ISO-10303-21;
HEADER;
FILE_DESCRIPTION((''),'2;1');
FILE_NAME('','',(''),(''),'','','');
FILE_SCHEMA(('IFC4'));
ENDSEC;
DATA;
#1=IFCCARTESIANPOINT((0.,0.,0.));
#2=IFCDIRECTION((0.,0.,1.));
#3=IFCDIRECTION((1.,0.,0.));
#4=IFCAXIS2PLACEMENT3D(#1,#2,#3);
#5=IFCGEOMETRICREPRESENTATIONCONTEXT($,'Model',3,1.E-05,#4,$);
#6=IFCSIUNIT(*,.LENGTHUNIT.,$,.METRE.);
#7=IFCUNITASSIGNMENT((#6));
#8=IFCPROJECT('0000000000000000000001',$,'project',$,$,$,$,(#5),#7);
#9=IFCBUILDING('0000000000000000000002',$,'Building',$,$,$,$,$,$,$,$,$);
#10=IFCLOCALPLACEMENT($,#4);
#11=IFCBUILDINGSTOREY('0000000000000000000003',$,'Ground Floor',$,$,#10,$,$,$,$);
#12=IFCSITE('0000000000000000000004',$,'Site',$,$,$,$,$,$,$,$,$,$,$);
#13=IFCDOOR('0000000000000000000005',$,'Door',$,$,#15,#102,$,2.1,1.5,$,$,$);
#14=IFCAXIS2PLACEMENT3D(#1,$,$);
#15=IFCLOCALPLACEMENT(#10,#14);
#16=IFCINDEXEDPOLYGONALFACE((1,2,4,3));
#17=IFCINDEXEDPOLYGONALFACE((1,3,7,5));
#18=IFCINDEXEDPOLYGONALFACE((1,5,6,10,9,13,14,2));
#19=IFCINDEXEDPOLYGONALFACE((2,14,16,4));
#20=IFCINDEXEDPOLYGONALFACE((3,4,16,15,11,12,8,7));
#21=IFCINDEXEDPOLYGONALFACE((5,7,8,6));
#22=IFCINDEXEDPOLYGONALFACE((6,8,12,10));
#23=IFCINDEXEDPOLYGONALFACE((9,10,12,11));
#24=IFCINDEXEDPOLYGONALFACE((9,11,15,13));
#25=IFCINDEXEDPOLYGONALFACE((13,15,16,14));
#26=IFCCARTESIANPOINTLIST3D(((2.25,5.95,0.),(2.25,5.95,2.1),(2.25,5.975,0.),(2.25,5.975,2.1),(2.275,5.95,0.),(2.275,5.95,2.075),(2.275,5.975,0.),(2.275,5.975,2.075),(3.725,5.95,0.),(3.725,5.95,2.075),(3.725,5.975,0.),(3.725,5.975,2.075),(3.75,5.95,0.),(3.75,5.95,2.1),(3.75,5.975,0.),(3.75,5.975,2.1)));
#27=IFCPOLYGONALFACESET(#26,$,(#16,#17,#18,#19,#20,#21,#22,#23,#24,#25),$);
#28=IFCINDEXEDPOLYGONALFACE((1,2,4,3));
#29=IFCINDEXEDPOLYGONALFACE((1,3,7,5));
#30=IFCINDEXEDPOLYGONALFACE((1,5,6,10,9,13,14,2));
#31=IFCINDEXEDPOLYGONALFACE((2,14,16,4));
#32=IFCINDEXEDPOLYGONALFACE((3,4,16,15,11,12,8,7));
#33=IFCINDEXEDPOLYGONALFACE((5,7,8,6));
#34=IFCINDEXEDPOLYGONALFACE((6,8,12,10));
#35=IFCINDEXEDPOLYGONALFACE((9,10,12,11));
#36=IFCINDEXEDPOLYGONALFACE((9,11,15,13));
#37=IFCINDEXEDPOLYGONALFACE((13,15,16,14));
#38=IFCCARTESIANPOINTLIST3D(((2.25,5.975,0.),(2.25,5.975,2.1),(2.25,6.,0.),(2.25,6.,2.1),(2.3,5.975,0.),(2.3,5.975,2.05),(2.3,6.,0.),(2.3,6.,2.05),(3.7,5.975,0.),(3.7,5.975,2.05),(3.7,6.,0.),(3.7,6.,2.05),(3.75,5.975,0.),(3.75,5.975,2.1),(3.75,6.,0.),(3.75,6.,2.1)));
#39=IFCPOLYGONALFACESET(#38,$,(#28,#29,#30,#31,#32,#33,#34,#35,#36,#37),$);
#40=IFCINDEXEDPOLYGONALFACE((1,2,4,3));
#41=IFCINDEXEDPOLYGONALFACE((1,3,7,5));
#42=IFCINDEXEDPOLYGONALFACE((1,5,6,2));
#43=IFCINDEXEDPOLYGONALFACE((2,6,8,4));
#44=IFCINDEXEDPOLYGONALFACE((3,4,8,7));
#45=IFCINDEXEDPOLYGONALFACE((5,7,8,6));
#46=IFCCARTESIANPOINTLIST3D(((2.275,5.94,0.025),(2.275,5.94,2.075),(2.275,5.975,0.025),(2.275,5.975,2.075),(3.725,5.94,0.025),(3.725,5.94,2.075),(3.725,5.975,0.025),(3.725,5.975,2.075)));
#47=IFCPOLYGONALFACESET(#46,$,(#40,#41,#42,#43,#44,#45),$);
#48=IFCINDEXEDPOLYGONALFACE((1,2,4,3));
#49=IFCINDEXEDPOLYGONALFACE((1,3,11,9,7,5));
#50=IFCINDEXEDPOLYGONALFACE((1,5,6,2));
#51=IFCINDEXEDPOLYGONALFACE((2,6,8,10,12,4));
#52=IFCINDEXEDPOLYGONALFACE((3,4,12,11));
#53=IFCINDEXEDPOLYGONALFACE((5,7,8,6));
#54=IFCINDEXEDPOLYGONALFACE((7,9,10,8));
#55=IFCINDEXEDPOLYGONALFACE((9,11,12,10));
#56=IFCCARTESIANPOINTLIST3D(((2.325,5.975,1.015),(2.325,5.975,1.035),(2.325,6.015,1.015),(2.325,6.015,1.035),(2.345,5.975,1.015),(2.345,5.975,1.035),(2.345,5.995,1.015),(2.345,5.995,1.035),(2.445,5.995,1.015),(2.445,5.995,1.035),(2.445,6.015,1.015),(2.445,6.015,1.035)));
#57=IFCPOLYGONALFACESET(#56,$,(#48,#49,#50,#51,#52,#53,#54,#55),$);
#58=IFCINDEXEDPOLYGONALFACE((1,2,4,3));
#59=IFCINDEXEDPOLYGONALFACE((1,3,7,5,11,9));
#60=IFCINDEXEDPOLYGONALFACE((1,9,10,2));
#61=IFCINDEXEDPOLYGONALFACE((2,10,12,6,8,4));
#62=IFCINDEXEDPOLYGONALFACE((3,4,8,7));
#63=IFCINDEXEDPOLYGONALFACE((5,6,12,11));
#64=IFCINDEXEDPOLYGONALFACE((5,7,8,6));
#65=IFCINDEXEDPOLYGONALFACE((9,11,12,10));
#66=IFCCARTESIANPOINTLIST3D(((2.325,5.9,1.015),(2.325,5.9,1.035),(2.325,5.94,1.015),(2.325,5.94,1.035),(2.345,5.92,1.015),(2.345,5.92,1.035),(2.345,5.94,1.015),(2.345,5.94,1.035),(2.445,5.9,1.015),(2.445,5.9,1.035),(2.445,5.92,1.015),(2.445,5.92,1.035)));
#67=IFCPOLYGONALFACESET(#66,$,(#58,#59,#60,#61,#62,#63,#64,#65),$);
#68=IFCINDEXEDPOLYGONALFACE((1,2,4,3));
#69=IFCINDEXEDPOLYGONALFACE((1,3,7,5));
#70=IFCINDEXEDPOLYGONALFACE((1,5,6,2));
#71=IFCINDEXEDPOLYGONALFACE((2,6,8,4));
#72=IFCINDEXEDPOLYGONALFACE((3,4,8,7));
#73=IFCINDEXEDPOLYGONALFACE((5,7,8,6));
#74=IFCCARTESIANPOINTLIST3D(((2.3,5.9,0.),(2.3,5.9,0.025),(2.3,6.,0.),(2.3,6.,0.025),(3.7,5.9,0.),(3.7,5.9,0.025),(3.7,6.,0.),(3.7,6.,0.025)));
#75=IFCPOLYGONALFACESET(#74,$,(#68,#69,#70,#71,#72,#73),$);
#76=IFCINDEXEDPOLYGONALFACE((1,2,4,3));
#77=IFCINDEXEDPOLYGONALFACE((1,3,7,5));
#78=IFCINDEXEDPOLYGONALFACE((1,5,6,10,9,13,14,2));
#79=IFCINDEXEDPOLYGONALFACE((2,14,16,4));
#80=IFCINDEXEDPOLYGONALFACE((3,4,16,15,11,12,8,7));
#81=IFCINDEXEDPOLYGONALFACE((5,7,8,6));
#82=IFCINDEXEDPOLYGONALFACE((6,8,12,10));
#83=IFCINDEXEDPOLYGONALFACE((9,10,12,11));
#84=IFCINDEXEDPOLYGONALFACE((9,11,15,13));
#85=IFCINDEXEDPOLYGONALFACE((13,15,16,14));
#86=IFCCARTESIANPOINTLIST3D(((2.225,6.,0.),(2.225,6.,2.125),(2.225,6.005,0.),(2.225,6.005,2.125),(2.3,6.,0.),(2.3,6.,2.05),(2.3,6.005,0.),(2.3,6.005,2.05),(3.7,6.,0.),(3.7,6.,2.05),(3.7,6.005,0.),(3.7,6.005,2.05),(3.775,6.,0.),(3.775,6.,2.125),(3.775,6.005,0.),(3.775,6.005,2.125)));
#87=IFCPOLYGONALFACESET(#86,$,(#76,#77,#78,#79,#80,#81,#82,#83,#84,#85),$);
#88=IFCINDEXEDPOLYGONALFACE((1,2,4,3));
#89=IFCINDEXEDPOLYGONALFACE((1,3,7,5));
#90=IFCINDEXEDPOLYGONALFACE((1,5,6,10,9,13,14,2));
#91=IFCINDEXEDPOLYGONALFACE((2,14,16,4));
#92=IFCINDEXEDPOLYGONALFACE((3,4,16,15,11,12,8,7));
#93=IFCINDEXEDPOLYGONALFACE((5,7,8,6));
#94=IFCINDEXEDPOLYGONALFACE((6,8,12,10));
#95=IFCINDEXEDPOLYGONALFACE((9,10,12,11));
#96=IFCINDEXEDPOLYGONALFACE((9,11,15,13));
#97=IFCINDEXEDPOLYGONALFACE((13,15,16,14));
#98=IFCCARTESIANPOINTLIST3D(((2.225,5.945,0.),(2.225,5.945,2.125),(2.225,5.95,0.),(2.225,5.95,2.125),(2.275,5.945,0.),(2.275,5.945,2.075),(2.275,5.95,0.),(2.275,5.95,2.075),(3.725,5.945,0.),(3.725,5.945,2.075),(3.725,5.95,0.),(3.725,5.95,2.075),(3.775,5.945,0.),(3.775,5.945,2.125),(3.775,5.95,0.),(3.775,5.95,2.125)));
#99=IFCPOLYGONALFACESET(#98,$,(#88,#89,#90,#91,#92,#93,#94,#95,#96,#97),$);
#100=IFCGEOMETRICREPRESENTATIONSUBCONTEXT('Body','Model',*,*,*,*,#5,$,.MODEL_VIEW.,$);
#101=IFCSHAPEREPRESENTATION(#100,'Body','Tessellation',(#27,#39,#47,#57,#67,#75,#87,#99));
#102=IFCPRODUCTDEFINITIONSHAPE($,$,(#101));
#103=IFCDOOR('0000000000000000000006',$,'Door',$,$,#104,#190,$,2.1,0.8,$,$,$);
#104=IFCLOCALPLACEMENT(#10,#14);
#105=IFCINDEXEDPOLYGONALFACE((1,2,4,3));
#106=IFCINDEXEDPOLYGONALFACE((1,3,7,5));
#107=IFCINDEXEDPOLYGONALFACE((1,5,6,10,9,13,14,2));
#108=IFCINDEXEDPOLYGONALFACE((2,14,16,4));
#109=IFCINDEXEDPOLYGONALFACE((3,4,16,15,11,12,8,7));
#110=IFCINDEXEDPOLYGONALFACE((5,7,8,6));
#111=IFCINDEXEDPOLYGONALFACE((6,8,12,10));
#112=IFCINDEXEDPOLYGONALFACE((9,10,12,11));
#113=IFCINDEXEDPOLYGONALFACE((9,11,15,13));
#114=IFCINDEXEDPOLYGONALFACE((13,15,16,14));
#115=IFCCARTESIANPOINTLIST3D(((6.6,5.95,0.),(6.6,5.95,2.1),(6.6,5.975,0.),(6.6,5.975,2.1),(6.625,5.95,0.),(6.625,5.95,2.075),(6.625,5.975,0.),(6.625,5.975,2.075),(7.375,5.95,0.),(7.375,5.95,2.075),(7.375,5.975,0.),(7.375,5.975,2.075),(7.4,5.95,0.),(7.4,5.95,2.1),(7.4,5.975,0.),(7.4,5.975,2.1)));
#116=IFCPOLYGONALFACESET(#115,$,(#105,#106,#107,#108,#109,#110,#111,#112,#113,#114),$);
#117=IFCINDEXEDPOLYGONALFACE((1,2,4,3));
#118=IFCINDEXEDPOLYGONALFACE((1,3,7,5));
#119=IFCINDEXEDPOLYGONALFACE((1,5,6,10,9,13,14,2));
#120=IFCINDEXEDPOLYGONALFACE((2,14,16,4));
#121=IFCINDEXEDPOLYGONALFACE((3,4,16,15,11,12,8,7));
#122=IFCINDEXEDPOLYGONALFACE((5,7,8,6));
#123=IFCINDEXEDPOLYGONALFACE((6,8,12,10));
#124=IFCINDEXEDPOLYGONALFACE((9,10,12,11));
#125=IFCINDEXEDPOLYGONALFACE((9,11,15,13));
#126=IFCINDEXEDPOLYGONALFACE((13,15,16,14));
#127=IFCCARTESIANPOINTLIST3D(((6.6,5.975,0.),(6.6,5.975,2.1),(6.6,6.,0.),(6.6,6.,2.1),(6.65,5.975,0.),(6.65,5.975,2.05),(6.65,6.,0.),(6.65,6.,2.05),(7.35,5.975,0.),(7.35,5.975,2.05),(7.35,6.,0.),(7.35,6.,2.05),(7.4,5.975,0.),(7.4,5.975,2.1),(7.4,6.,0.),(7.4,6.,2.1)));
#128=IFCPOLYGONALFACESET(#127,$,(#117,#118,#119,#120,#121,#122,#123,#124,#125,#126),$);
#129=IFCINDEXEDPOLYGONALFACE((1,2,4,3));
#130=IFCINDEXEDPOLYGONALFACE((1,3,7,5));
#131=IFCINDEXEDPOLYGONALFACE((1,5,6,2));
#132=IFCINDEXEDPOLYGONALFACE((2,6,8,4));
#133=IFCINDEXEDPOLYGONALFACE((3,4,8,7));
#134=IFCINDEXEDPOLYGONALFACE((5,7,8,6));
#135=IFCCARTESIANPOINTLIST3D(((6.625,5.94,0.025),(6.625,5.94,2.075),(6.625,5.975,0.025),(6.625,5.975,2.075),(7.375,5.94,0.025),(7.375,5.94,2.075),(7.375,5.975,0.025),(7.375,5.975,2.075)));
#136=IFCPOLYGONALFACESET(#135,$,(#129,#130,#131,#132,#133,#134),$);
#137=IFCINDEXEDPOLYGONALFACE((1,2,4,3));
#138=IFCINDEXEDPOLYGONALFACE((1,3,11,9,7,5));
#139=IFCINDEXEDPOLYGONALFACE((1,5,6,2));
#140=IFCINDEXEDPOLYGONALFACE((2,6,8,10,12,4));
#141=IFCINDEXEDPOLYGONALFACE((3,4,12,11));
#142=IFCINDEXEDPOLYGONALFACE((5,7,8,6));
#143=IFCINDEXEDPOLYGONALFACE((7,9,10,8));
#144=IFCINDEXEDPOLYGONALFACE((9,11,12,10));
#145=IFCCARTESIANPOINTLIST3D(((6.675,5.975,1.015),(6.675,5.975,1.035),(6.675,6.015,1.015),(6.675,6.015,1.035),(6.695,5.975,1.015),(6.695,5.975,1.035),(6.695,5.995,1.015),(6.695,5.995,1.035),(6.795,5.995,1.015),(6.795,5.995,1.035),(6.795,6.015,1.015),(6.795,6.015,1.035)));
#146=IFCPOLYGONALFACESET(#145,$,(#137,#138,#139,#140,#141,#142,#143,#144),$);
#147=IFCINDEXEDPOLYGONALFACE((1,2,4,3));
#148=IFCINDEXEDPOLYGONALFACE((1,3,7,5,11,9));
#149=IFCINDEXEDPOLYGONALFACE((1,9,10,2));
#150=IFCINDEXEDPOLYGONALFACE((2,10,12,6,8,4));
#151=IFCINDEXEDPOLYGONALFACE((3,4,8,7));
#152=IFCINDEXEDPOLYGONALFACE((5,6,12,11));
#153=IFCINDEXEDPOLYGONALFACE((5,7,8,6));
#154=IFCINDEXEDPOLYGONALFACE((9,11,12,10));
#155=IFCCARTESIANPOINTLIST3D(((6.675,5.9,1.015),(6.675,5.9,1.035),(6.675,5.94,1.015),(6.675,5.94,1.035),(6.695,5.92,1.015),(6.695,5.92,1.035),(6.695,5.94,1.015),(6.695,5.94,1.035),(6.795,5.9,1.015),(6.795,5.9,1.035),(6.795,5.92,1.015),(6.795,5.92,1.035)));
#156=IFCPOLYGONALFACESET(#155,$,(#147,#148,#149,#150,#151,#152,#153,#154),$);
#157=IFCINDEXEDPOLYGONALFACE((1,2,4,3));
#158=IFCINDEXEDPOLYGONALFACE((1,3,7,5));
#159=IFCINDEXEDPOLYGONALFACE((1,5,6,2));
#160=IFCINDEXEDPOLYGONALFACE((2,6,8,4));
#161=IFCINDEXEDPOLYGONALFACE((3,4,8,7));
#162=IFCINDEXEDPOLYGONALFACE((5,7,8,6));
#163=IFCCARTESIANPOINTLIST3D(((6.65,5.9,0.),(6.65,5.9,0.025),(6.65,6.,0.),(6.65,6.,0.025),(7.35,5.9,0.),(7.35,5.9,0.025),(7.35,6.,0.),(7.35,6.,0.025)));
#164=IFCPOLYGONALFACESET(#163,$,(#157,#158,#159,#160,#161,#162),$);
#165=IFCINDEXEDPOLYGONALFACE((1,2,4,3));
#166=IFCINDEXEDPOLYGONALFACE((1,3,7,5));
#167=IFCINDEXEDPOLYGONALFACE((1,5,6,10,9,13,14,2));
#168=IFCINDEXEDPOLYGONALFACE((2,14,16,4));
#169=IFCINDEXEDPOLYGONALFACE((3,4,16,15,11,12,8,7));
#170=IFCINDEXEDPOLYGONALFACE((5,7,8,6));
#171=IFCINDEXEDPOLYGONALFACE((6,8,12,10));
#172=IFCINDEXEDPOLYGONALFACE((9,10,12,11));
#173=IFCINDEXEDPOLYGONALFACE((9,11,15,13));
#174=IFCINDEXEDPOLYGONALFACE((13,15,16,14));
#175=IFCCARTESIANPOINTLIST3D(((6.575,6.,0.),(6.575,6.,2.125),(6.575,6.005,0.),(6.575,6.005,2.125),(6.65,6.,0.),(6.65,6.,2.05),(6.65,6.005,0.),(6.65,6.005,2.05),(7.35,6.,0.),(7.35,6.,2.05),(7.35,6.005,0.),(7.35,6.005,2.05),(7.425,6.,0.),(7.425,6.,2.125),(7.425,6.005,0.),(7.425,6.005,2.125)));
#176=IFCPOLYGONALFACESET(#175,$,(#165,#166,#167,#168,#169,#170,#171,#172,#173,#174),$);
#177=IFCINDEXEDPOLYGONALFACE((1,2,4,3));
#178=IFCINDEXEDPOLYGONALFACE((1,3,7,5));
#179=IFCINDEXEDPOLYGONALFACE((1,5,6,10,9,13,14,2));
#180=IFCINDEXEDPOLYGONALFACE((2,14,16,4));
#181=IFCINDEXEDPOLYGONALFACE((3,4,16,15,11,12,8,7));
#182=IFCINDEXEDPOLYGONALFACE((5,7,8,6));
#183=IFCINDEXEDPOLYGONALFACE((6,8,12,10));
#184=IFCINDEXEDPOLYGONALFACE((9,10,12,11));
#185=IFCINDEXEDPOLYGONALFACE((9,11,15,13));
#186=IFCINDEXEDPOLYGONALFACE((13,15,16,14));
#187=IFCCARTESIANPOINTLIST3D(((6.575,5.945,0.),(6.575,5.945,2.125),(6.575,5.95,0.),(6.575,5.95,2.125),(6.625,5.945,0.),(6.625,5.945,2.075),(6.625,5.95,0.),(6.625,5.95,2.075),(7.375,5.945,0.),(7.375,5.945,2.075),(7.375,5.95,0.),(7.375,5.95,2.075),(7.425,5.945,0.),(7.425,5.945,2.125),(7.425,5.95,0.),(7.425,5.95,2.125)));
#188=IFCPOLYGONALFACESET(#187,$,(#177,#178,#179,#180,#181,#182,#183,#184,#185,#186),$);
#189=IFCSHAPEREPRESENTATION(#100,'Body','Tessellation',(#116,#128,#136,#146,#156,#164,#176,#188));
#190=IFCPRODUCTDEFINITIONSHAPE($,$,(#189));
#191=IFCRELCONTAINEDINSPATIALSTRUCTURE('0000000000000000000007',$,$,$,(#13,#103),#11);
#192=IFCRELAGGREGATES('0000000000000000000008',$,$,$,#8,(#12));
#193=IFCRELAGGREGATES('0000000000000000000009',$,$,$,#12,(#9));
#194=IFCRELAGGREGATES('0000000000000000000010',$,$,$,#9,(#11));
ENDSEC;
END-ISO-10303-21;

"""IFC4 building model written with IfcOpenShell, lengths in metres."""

from ifc_helpers import new_model, si_unit, frame, origin_with_axes, place, context, subcontext, project, spatial, line, indexed_curve, outline, extrude, element, save


model = new_model("IFC4")

# Units and contexts
model_context = context("Model", 3, precision=1e-05, world=origin_with_axes())
body_context = subcontext(model_context, "Body", "Model", "MODEL_VIEW")
ifc_project = project(units=[si_unit("LENGTHUNIT", "METRE")], contexts=[model_context])

# Site, building, storey
site = spatial("IfcSite", under=ifc_project, Name="Site")
building = spatial("IfcBuilding", under=site, Name="Building")
storey_placement = place(None, origin_with_axes())
storey = spatial("IfcBuildingStorey", under=building, at=storey_placement, Name="Ground Floor")

# Doors
door_1_placement = place(storey_placement, frame((3.75, 6.0, 0.0), z_axis=(0.0, 0.0, 1.0), x_axis=(-1.0, 0.0, 0.0)))
element("IfcDoor", 1, at=door_1_placement, inside=storey, Name="Door", OverallHeight=2.1, OverallWidth=1.5, context=body_context, shape_type="SweptSolid", body=[
    extrude(outline(indexed_curve([(0.0, 0.0), (0.0, 2.1), (1.5, 2.1), (1.5, 0.0), (1.475, 0.0), (1.475, 2.075), (0.025, 2.075), (0.025, 0.0)], segments=[line(1, 2, 3, 4, 5, 6, 7, 8, 1)])), frame((0.0, 0.025, 0.0), z_axis=(0.0, -1.0, 0.0), x_axis=(1.0, 0.0, 0.0)), (0.0, 0.0, -1.0), 0.025),
    extrude(outline(indexed_curve([(0.0, 0.0), (0.0, 2.1), (1.5, 2.1), (1.5, 0.0), (1.45, 0.0), (1.45, 2.05), (0.05, 2.05), (0.05, 0.0)], segments=[line(1, 2, 3, 4, 5, 6, 7, 8, 1)])), frame((0.0, 0.0, 0.0), z_axis=(0.0, -1.0, 0.0), x_axis=(1.0, 0.0, 0.0)), (0.0, 0.0, -1.0), 0.025),
    extrude(outline(indexed_curve([(0.0, 0.0), (1.45, 0.0), (1.45, 0.035), (0.0, 0.035)], segments=[line(1, 2, 3, 4, 1)])), frame((0.025, 0.025, 0.025), z_axis=(0.0, 0.0, 1.0), x_axis=(1.0, 0.0, 0.0)), (0.0, 0.0, 1.0), 2.05),
    extrude(outline(indexed_curve([(0.0, 0.0), (0.0, -0.04), (-0.12, -0.04), (-0.12, -0.02), (-0.02, -0.02), (-0.02, 0.0)], segments=[line(1, 2, 3, 4, 5, 6, 1)])), frame((1.425, 0.025, 1.015), z_axis=(0.0, 0.0, 1.0), x_axis=(1.0, 0.0, 0.0)), (0.0, 0.0, 1.0), 0.02),
    extrude(outline(indexed_curve([(0.0, 0.0), (0.0, 0.04), (-0.12, 0.04), (-0.12, 0.02), (-0.02, 0.02), (-0.02, 0.0)], segments=[line(1, 2, 3, 4, 5, 6, 1)])), frame((1.425, 0.06, 1.015), z_axis=(0.0, 0.0, 1.0), x_axis=(1.0, 0.0, 0.0)), (0.0, 0.0, 1.0), 0.02),
    extrude(outline(indexed_curve([(0.0, 0.0), (1.4, 0.0), (1.4, 0.1), (0.0, 0.1)], segments=[line(1, 2, 3, 4, 1)])), frame((0.05, 0.0, 0.0), z_axis=(0.0, 0.0, 1.0), x_axis=(1.0, 0.0, 0.0)), (0.0, 0.0, 1.0), 0.025),
    extrude(outline(indexed_curve([(0.0, 0.0), (0.0, 2.125), (1.55, 2.125), (1.55, 0.0), (1.475, 0.0), (1.475, 2.05), (0.075, 2.05), (0.075, 0.0)], segments=[line(1, 2, 3, 4, 5, 6, 7, 8, 1)])), frame((-0.025, -0.005, 0.0), z_axis=(0.0, -1.0, 0.0), x_axis=(1.0, 0.0, 0.0)), (0.0, 0.0, -1.0), 0.005),
    extrude(outline(indexed_curve([(0.0, 0.0), (0.0, 2.125), (1.55, 2.125), (1.55, 0.0), (1.5, 0.0), (1.5, 2.075), (0.05, 2.075), (0.05, 0.0)], segments=[line(1, 2, 3, 4, 5, 6, 7, 8, 1)])), frame((-0.025, 0.05, 0.0), z_axis=(0.0, -1.0, 0.0), x_axis=(1.0, 0.0, 0.0)), (0.0, 0.0, -1.0), 0.005),
])
door_2_placement = place(storey_placement, frame((7.4, 6.0, 0.0), z_axis=(0.0, 0.0, 1.0), x_axis=(-1.0, 0.0, 0.0)))
element("IfcDoor", 2, at=door_2_placement, inside=storey, Name="Door", OverallHeight=2.1, OverallWidth=0.8, context=body_context, shape_type="SweptSolid", body=[
    extrude(outline(indexed_curve([(0.0, 0.0), (0.0, 2.1), (0.8, 2.1), (0.8, 0.0), (0.775, 0.0), (0.775, 2.075), (0.025, 2.075), (0.025, 0.0)], segments=[line(1, 2, 3, 4, 5, 6, 7, 8, 1)])), frame((0.0, 0.025, 0.0), z_axis=(0.0, -1.0, 0.0), x_axis=(1.0, 0.0, 0.0)), (0.0, 0.0, -1.0), 0.025),
    extrude(outline(indexed_curve([(0.0, 0.0), (0.0, 2.1), (0.8, 2.1), (0.8, 0.0), (0.75, 0.0), (0.75, 2.05), (0.05, 2.05), (0.05, 0.0)], segments=[line(1, 2, 3, 4, 5, 6, 7, 8, 1)])), frame((0.0, 0.0, 0.0), z_axis=(0.0, -1.0, 0.0), x_axis=(1.0, 0.0, 0.0)), (0.0, 0.0, -1.0), 0.025),
    extrude(outline(indexed_curve([(0.0, 0.0), (0.75, 0.0), (0.75, 0.035), (0.0, 0.035)], segments=[line(1, 2, 3, 4, 1)])), frame((0.025, 0.025, 0.025), z_axis=(0.0, 0.0, 1.0), x_axis=(1.0, 0.0, 0.0)), (0.0, 0.0, 1.0), 2.05),
    extrude(outline(indexed_curve([(0.0, 0.0), (0.0, -0.04), (-0.12, -0.04), (-0.12, -0.02), (-0.02, -0.02), (-0.02, 0.0)], segments=[line(1, 2, 3, 4, 5, 6, 1)])), frame((0.725, 0.025, 1.015), z_axis=(0.0, 0.0, 1.0), x_axis=(1.0, 0.0, 0.0)), (0.0, 0.0, 1.0), 0.02),
    extrude(outline(indexed_curve([(0.0, 0.0), (0.0, 0.04), (-0.12, 0.04), (-0.12, 0.02), (-0.02, 0.02), (-0.02, 0.0)], segments=[line(1, 2, 3, 4, 5, 6, 1)])), frame((0.725, 0.06, 1.015), z_axis=(0.0, 0.0, 1.0), x_axis=(1.0, 0.0, 0.0)), (0.0, 0.0, 1.0), 0.02),
    extrude(outline(indexed_curve([(0.0, 0.0), (0.7, 0.0), (0.7, 0.1), (0.0, 0.1)], segments=[line(1, 2, 3, 4, 1)])), frame((0.05, 0.0, 0.0), z_axis=(0.0, 0.0, 1.0), x_axis=(1.0, 0.0, 0.0)), (0.0, 0.0, 1.0), 0.025),
    extrude(outline(indexed_curve([(0.0, 0.0), (0.0, 2.125), (0.85, 2.125), (0.85, 0.0), (0.775, 0.0), (0.775, 2.05), (0.075, 2.05), (0.075, 0.0)], segments=[line(1, 2, 3, 4, 5, 6, 7, 8, 1)])), frame((-0.025, -0.005, 0.0), z_axis=(0.0, -1.0, 0.0), x_axis=(1.0, 0.0, 0.0)), (0.0, 0.0, -1.0), 0.005),
    extrude(outline(indexed_curve([(0.0, 0.0), (0.0, 2.125), (0.85, 2.125), (0.85, 0.0), (0.8, 0.0), (0.8, 2.075), (0.05, 2.075), (0.05, 0.0)], segments=[line(1, 2, 3, 4, 5, 6, 7, 8, 1)])), frame((-0.025, 0.05, 0.0), z_axis=(0.0, -1.0, 0.0), x_axis=(1.0, 0.0, 0.0)), (0.0, 0.0, -1.0), 0.005),
])

save(model, "model.ifc")
